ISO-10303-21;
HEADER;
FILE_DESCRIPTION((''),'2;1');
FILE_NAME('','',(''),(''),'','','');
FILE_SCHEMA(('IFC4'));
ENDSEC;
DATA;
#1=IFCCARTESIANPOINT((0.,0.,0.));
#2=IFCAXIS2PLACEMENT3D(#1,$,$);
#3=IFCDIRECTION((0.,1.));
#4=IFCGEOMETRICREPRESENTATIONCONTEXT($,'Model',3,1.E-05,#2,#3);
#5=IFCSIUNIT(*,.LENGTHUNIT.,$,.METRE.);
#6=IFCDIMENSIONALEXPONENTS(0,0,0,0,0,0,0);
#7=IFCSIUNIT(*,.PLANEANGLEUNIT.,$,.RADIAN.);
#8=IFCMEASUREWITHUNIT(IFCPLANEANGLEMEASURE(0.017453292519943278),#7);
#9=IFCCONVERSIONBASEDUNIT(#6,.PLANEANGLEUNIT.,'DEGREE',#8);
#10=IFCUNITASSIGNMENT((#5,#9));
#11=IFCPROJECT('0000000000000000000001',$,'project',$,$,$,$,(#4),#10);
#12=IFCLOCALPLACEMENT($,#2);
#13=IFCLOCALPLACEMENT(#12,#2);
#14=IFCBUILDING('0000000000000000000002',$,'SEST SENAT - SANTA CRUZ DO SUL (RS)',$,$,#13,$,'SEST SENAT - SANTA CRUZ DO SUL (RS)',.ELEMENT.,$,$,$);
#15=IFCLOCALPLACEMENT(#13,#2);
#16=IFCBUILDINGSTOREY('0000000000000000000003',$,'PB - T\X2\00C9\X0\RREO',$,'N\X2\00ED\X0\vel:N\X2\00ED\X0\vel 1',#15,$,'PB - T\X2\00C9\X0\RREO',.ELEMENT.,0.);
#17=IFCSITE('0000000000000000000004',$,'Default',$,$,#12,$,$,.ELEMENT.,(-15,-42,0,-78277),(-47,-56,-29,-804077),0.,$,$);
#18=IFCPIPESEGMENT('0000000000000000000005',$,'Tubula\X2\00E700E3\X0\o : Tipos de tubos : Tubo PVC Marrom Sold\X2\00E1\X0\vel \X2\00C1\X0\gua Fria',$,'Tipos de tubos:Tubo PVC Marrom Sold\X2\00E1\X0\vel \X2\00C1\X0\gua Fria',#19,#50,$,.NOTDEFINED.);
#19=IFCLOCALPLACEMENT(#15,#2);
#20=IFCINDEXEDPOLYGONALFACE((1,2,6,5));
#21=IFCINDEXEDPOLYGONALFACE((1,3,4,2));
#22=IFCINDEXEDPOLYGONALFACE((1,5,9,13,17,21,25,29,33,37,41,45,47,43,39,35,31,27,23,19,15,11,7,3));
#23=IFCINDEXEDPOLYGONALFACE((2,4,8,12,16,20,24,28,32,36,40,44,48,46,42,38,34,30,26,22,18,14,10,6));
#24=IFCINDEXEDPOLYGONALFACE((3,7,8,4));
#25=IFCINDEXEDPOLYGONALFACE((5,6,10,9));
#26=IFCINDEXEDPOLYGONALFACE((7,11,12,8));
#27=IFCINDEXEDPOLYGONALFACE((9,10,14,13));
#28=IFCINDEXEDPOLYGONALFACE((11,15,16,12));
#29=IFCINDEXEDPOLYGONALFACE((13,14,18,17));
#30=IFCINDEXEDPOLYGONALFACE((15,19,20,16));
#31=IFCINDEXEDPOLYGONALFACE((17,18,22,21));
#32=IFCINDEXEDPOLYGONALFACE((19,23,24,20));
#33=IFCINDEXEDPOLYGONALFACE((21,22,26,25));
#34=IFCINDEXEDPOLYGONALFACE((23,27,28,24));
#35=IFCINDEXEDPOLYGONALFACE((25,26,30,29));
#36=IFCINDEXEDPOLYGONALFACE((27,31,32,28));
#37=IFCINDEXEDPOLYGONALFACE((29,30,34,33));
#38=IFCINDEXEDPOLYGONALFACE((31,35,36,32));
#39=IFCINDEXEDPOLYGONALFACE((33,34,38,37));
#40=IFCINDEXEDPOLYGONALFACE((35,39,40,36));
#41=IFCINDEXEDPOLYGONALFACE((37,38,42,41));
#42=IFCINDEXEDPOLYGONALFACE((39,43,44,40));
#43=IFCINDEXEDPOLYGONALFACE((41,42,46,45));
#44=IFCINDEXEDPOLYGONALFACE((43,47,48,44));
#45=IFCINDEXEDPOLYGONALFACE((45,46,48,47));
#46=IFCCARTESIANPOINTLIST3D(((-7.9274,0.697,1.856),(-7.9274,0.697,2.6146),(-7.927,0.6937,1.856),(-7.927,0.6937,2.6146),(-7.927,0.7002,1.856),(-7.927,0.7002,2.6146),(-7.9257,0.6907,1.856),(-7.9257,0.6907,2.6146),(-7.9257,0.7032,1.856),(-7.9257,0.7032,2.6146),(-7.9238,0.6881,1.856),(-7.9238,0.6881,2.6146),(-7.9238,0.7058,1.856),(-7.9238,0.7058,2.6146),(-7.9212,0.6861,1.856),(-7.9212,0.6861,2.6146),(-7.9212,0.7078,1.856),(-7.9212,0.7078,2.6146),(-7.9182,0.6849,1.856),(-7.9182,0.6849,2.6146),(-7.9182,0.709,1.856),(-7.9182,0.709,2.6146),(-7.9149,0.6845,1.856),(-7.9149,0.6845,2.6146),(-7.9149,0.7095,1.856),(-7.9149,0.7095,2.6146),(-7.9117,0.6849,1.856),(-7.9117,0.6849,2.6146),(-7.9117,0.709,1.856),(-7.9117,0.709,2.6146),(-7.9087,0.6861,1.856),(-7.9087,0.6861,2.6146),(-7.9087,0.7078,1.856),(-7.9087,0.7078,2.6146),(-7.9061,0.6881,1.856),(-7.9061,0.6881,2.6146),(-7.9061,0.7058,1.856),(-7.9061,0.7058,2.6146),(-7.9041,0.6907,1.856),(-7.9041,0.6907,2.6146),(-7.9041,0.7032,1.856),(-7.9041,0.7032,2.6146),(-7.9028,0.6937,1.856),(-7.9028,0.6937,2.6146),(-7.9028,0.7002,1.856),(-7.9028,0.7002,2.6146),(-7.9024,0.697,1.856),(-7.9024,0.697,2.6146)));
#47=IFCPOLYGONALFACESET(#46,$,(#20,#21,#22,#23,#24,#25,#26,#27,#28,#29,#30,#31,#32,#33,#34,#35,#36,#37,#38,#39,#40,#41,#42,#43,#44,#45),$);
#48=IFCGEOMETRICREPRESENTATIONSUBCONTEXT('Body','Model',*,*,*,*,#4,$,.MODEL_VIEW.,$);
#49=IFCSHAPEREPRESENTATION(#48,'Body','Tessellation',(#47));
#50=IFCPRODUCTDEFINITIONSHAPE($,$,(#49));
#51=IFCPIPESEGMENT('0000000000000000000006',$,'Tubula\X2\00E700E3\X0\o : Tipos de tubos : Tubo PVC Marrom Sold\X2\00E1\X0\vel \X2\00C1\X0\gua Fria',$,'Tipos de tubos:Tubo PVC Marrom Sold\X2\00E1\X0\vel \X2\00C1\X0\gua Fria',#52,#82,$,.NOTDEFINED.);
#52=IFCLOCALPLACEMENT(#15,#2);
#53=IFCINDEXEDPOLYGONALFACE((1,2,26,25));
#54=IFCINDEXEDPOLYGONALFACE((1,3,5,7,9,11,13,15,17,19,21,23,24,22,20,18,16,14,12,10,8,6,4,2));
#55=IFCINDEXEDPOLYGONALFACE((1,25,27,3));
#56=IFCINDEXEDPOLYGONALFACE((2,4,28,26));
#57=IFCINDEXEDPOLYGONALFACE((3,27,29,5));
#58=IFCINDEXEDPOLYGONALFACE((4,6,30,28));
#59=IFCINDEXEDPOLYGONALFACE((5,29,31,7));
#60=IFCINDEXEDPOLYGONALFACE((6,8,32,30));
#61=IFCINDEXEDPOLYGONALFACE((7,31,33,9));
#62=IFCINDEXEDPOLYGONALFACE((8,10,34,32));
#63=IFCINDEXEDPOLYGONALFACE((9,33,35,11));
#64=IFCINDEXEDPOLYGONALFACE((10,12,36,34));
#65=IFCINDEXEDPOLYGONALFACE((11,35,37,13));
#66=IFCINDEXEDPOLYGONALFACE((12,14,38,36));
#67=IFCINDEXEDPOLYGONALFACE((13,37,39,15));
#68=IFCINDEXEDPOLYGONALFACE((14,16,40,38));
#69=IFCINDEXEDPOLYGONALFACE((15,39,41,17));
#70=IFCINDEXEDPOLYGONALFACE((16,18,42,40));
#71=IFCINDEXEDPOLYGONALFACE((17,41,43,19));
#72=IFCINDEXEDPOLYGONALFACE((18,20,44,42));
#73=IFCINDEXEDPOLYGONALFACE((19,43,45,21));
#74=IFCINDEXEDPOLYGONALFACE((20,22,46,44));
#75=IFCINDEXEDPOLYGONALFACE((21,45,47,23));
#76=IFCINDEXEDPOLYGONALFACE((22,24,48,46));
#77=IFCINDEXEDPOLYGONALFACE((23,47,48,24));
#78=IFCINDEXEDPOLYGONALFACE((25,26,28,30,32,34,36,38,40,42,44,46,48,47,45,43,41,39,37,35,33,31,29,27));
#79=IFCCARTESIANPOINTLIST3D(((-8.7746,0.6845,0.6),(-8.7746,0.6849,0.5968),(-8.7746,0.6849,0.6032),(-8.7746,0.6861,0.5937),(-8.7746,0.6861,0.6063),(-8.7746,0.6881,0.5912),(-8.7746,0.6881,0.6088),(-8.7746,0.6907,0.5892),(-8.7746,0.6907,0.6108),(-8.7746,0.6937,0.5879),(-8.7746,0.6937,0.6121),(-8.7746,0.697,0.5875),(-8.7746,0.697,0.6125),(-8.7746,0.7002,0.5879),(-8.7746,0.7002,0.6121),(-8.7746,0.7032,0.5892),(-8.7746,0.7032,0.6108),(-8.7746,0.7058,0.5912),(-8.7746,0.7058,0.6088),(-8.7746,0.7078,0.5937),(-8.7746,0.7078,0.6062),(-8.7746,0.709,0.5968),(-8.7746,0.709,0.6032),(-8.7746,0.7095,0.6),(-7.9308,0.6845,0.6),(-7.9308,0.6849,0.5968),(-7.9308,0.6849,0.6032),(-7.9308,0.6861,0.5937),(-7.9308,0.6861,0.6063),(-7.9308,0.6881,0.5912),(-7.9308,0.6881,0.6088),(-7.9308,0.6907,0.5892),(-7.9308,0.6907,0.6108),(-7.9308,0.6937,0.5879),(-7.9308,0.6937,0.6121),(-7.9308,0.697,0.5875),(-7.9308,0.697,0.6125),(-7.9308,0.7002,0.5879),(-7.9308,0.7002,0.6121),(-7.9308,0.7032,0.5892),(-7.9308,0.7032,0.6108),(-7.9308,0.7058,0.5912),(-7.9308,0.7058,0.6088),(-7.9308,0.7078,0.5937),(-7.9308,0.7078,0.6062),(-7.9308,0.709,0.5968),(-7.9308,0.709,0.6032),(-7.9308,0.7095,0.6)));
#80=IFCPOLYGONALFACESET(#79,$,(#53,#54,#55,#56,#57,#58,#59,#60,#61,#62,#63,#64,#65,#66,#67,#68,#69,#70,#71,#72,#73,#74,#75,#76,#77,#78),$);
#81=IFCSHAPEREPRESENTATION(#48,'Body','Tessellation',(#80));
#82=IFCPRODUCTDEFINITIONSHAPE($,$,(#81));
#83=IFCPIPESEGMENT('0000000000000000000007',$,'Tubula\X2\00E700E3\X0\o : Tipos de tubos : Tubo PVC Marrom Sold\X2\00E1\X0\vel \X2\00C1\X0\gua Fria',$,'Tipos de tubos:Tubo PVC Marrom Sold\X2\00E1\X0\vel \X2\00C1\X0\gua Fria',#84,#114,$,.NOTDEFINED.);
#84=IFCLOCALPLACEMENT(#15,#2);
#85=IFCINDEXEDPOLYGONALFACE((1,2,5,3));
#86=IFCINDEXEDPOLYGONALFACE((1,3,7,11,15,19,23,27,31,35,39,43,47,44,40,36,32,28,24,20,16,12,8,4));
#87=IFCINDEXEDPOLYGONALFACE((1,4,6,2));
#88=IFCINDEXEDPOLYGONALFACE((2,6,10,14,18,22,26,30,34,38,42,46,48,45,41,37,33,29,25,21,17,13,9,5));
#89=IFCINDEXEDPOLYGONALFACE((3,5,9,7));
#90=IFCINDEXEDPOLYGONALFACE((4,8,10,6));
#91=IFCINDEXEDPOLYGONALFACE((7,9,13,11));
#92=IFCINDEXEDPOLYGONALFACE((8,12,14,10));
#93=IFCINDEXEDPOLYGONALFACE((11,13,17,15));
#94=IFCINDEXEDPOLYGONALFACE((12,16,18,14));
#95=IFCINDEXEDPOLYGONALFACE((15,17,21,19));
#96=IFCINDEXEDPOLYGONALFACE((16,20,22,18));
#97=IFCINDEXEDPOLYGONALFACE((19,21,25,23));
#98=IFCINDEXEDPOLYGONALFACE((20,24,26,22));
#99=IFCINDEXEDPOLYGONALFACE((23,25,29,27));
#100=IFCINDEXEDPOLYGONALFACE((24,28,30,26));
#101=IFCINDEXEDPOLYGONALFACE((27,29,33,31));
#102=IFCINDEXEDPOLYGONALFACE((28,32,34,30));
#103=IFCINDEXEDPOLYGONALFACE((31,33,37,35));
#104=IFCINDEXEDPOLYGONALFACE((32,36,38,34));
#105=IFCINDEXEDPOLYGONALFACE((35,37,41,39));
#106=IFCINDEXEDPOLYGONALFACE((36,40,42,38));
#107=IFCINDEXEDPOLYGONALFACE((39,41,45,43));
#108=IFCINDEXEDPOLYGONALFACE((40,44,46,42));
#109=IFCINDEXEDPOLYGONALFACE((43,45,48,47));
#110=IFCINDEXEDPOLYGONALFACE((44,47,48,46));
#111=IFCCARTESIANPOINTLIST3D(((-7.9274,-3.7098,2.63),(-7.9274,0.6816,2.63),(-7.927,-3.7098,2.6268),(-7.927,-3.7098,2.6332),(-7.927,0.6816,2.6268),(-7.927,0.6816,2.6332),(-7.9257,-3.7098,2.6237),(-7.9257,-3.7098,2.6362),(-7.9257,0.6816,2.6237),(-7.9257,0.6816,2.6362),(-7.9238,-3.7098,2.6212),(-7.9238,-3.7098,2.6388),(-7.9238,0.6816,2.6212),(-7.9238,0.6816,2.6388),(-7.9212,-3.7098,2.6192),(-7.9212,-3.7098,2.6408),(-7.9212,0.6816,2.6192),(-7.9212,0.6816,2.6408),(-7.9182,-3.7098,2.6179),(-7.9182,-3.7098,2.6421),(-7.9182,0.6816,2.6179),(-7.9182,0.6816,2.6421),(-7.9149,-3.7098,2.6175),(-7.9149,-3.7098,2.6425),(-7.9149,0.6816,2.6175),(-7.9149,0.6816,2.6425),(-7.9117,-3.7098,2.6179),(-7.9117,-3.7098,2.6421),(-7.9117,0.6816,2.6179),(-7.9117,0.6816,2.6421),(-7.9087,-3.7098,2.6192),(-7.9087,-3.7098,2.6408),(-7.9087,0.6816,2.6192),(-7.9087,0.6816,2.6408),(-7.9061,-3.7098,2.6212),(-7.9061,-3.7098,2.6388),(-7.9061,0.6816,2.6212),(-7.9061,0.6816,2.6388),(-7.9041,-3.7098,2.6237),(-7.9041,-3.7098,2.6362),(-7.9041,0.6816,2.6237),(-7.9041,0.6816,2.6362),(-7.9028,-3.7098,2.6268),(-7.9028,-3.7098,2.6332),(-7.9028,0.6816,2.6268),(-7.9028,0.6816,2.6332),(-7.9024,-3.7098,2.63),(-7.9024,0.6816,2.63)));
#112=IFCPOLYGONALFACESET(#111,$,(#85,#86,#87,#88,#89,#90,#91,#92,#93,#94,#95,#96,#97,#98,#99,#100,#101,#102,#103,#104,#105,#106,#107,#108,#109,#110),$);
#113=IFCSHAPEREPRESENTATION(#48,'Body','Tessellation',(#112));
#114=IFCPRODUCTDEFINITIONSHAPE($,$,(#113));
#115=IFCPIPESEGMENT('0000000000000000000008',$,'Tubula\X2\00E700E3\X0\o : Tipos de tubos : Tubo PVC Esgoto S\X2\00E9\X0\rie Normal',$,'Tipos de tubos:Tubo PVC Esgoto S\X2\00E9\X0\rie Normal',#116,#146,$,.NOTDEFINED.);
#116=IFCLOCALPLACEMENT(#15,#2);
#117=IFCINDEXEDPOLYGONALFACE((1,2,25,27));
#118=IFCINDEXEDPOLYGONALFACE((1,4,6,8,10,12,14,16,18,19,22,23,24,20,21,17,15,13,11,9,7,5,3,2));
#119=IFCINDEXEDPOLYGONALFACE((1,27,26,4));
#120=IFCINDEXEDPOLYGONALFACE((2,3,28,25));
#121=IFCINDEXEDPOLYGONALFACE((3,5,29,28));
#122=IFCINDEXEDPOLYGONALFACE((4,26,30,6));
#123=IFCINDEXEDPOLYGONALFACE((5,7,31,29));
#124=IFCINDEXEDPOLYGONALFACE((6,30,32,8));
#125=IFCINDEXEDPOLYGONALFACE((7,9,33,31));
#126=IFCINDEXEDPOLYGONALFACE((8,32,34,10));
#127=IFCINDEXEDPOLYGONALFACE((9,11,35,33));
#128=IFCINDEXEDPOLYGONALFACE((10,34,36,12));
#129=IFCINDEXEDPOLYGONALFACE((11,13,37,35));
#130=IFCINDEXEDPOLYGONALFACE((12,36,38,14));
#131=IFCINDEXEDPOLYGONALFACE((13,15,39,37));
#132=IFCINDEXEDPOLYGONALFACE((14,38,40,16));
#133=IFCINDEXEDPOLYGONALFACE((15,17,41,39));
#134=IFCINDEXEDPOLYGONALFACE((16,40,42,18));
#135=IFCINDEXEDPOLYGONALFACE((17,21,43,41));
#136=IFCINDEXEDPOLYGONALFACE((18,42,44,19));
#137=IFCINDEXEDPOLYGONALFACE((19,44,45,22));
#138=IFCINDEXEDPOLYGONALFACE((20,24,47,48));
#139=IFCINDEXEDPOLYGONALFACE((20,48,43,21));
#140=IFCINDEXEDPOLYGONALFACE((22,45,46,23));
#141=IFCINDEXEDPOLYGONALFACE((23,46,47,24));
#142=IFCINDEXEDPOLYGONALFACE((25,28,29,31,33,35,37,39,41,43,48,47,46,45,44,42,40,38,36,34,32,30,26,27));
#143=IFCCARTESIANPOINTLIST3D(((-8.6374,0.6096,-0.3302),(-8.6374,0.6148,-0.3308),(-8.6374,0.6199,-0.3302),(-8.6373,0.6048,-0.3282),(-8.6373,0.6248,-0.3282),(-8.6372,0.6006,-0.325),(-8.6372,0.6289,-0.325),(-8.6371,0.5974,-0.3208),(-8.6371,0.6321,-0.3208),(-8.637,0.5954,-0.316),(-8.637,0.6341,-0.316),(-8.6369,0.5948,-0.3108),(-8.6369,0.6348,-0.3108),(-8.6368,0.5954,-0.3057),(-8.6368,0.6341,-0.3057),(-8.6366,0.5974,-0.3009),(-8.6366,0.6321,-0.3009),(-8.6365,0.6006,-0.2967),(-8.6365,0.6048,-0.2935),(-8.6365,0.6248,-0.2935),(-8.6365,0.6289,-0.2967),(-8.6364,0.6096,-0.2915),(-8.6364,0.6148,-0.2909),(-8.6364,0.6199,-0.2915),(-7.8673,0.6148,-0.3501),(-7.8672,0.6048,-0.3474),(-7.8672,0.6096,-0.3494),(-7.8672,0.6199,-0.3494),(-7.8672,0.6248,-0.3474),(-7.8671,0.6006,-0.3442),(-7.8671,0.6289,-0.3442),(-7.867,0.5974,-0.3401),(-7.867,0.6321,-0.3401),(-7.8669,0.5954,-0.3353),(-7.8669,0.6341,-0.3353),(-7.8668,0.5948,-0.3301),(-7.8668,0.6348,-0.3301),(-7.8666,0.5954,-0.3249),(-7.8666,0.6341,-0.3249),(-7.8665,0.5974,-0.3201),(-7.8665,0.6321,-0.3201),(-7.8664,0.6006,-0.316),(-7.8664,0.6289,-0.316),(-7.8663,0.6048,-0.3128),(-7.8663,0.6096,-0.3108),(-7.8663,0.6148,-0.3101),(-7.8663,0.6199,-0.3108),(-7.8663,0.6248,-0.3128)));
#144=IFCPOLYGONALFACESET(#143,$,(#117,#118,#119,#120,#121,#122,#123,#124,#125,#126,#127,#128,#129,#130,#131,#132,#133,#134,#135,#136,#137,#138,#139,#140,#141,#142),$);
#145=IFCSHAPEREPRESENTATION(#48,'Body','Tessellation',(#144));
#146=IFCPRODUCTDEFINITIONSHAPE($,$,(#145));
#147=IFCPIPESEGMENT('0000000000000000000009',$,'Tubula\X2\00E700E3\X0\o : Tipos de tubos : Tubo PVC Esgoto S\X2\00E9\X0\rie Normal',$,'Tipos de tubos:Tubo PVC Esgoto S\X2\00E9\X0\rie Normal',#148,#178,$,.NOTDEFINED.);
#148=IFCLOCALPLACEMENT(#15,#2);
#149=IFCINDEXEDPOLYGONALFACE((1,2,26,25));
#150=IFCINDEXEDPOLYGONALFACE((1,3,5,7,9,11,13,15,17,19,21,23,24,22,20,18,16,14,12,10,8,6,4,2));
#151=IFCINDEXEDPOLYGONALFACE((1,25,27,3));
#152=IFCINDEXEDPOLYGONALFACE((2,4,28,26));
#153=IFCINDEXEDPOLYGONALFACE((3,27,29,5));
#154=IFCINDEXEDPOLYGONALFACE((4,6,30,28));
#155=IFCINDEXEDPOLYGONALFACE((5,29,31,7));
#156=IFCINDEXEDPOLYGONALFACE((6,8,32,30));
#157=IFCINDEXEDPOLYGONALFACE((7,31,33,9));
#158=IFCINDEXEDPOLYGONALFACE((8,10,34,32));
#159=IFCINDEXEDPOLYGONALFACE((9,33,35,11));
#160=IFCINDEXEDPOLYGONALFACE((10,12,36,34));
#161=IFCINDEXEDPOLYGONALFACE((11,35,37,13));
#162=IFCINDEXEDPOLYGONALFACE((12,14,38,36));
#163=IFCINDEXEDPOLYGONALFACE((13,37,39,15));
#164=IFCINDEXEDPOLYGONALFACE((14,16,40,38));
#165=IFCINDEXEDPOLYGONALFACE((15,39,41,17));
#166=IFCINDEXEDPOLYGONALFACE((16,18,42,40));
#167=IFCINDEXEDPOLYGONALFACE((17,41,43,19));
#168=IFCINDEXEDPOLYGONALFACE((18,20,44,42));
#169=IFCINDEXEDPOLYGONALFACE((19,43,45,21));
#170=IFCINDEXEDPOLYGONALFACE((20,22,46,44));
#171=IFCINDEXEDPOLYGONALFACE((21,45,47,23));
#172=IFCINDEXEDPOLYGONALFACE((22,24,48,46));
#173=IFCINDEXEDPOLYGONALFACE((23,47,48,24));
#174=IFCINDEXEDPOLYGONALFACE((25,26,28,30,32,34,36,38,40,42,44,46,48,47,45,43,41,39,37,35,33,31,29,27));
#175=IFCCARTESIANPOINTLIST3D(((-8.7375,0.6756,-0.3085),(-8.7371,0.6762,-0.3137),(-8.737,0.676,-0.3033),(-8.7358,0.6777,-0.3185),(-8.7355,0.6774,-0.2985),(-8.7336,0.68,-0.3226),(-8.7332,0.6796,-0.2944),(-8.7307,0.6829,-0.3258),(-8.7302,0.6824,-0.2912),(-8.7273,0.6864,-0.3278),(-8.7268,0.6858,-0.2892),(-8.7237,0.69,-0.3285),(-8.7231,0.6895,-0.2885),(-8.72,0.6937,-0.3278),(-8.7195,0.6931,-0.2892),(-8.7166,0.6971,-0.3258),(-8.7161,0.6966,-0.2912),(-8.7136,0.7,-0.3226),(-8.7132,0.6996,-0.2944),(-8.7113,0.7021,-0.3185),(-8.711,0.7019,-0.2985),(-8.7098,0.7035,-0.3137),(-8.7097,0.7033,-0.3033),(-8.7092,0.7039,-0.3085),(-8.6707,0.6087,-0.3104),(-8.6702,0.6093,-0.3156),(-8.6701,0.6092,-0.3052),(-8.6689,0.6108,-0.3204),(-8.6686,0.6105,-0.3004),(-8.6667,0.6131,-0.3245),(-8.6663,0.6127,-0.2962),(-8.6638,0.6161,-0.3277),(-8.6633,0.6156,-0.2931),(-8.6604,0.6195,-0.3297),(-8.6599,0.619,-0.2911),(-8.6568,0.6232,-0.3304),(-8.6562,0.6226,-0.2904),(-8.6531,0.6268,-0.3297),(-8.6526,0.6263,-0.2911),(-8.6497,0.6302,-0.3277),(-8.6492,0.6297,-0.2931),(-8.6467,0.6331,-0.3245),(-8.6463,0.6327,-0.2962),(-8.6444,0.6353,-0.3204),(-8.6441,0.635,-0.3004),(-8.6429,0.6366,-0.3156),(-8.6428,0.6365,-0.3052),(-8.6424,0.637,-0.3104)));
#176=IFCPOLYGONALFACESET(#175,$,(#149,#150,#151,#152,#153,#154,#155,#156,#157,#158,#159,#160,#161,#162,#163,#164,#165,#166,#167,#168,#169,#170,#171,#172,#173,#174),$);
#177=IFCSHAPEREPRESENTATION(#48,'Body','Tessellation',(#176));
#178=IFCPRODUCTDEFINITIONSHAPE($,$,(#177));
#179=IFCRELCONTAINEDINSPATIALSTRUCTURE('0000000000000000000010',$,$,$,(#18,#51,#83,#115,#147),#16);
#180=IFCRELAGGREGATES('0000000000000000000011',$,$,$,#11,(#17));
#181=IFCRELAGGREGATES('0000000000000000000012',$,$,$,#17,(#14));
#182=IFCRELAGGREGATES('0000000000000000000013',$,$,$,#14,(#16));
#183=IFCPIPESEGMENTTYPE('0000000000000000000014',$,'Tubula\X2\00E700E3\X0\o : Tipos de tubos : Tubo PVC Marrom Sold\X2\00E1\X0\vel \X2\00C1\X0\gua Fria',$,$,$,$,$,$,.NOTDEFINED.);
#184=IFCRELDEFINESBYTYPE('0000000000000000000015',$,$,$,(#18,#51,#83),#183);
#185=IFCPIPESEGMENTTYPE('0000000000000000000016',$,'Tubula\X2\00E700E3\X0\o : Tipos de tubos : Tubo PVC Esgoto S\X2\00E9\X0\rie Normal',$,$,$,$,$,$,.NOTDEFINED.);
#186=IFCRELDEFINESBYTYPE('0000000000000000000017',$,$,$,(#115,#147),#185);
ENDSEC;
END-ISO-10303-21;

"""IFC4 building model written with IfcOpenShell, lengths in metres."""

from ifc_helpers import new_model, entity, si_unit, converted_unit, direction, frame, origin, place, context, subcontext, project, spatial, arc, indexed_curve, outline, extrude, type_object, element, save


model = new_model("IFC4")

# Units and contexts
model_context = context("Model", 3, precision=1e-05, world=origin(), true_north=direction((0.0, 1.0)))
body_context = subcontext(model_context, "Body", "Model", "MODEL_VIEW")
ifc_project = project(units=[si_unit("LENGTHUNIT", "METRE"), converted_unit("PLANEANGLEUNIT", "DEGREE", entity("IfcPlaneAngleMeasure", 0.017453292519943278), si_unit("PLANEANGLEUNIT", "RADIAN"), dimensions=[0, 0, 0, 0, 0, 0, 0])], contexts=[model_context])

# Site, building, storey
site_placement = place(None, origin())
site = spatial("IfcSite", under=ifc_project, at=site_placement, Name="Default", CompositionType="ELEMENT", RefLatitude=(-15, -42, 0, -78277), RefLongitude=(-47, -56, -29, -804077), RefElevation=0.0)
building_placement = place(site_placement, origin())
building = spatial("IfcBuilding", under=site, at=building_placement, Name="SEST SENAT - SANTA CRUZ DO SUL (RS)", LongName="SEST SENAT - SANTA CRUZ DO SUL (RS)", CompositionType="ELEMENT")
storey_placement = place(building_placement, origin())
storey = spatial("IfcBuildingStorey", under=building, at=storey_placement, Name="PB - TÉRREO", ObjectType="Nível:Nível 1", LongName="PB - TÉRREO", CompositionType="ELEMENT", Elevation=0.0)

# Pipe segments
pipe_segment_type_1 = type_object("IfcPipeSegmentType", Name="Tubulação : Tipos de tubos : Tubo PVC Marrom Soldável Água Fria", PredefinedType="NOTDEFINED")
pipe_segment_1_placement = place(storey_placement, frame((-7.929, 0.6829, 1.856)))
element("IfcPipeSegment", 1, at=pipe_segment_1_placement, inside=storey, type_object=pipe_segment_type_1, Name="Tubulação : Tipos de tubos : Tubo PVC Marrom Soldável Água Fria", ObjectType="Tipos de tubos:Tubo PVC Marrom Soldável Água Fria", PredefinedType="NOTDEFINED", context=body_context, shape_type="SweptSolid", body=[
    extrude(outline(indexed_curve([(0.0125, 0.0), (0.0088, 0.0088), (0.0, 0.0125), (-0.0088, 0.0088), (-0.0125, 0.0), (-0.0088, -0.0088), (0.0, -0.0125), (0.0088, -0.0088)], segments=[arc(1, 2, 3), arc(3, 4, 5), arc(5, 6, 7), arc(7, 8, 1)], self_intersect=False)), frame((0.0141, 0.0141, 0.0)), (0.0, 0.0, 1.0), 0.7586),
])
pipe_segment_2_placement = place(storey_placement, frame((-8.7746, 0.6829, 0.6141)))
element("IfcPipeSegment", 2, at=pipe_segment_2_placement, inside=storey, type_object=pipe_segment_type_1, Name="Tubulação : Tipos de tubos : Tubo PVC Marrom Soldável Água Fria", ObjectType="Tipos de tubos:Tubo PVC Marrom Soldável Água Fria", PredefinedType="NOTDEFINED", context=body_context, shape_type="SweptSolid", body=[
    extrude(outline(indexed_curve([(0.0125, 0.0), (0.0088, 0.0088), (0.0, 0.0125), (-0.0088, 0.0088), (-0.0125, 0.0), (-0.0088, -0.0088), (0.0, -0.0125), (0.0088, -0.0088)], segments=[arc(1, 2, 3), arc(3, 4, 5), arc(5, 6, 7), arc(7, 8, 1)], self_intersect=False)), frame((0.0, 0.0141, -0.0141), z_axis=(1.0, 0.0, 0.0), x_axis=(0.0, -1.0, 0.0)), (0.0, 0.0, 1.0), 0.8438),
])
pipe_segment_3_placement = place(storey_placement, frame((-7.929, -3.7098, 2.6159)))
element("IfcPipeSegment", 3, at=pipe_segment_3_placement, inside=storey, type_object=pipe_segment_type_1, Name="Tubulação : Tipos de tubos : Tubo PVC Marrom Soldável Água Fria", ObjectType="Tipos de tubos:Tubo PVC Marrom Soldável Água Fria", PredefinedType="NOTDEFINED", context=body_context, shape_type="SweptSolid", body=[
    extrude(outline(indexed_curve([(0.0125, 0.0), (0.0088, 0.0088), (0.0, 0.0125), (-0.0088, 0.0088), (-0.0125, 0.0), (-0.0088, -0.0088), (0.0, -0.0125), (0.0088, -0.0088)], segments=[arc(1, 2, 3), arc(3, 4, 5), arc(5, 6, 7), arc(7, 8, 1)], self_intersect=False)), frame((0.0141, 0.0, 0.0141), z_axis=(0.0, 1.0, 0.0), x_axis=(1.0, 0.0, 0.0)), (0.0, 0.0, 1.0), 4.3914),
])
pipe_segment_type_2 = type_object("IfcPipeSegmentType", Name="Tubulação : Tipos de tubos : Tubo PVC Esgoto Série Normal", PredefinedType="NOTDEFINED")
pipe_segment_4_placement = place(storey_placement, frame((-8.639, 0.5932, -0.2893)))
element("IfcPipeSegment", 4, at=pipe_segment_4_placement, inside=storey, type_object=pipe_segment_type_2, Name="Tubulação : Tipos de tubos : Tubo PVC Esgoto Série Normal", ObjectType="Tipos de tubos:Tubo PVC Esgoto Série Normal", PredefinedType="NOTDEFINED", context=body_context, shape_type="SweptSolid", body=[
    extrude(outline(indexed_curve([(0.02, 0.0), (0.0141, 0.0141), (0.0, 0.02), (-0.0141, 0.0141), (-0.02, 0.0), (-0.0141, -0.0141), (0.0, -0.02), (0.0141, -0.0141)], segments=[arc(1, 2, 3), arc(3, 4, 5), arc(5, 6, 7), arc(7, 8, 1)], self_intersect=False)), frame((0.0021, 0.0216, -0.0216), z_axis=(0.999688, 0.0, -0.024979), x_axis=(0.0, 1.0, 0.0)), (0.0, 0.0, 1.0), 0.7704),
])
pipe_segment_5_placement = place(storey_placement, frame((-8.7391, 0.6071, -0.2869)))
element("IfcPipeSegment", 5, at=pipe_segment_5_placement, inside=storey, type_object=pipe_segment_type_2, Name="Tubulação : Tipos de tubos : Tubo PVC Esgoto Série Normal", ObjectType="Tipos de tubos:Tubo PVC Esgoto Série Normal", PredefinedType="NOTDEFINED", context=body_context, shape_type="SweptSolid", body=[
    extrude(outline(indexed_curve([(0.02, 0.0), (0.0141, 0.0141), (0.0, 0.02), (-0.0141, 0.0141), (-0.02, 0.0), (-0.0141, -0.0141), (0.0, -0.02), (0.0141, -0.0141)], segments=[arc(1, 2, 3), arc(3, 4, 5), arc(5, 6, 7), arc(7, 8, 1)], self_intersect=False)), frame((0.0826, 0.0157, -0.0235), z_axis=(-0.706965, 0.706965, 0.019996), x_axis=(0.707107, 0.707107, 0.0)), (0.0, 0.0, 1.0), 0.0946),
])

save(model, "model.ifc")
